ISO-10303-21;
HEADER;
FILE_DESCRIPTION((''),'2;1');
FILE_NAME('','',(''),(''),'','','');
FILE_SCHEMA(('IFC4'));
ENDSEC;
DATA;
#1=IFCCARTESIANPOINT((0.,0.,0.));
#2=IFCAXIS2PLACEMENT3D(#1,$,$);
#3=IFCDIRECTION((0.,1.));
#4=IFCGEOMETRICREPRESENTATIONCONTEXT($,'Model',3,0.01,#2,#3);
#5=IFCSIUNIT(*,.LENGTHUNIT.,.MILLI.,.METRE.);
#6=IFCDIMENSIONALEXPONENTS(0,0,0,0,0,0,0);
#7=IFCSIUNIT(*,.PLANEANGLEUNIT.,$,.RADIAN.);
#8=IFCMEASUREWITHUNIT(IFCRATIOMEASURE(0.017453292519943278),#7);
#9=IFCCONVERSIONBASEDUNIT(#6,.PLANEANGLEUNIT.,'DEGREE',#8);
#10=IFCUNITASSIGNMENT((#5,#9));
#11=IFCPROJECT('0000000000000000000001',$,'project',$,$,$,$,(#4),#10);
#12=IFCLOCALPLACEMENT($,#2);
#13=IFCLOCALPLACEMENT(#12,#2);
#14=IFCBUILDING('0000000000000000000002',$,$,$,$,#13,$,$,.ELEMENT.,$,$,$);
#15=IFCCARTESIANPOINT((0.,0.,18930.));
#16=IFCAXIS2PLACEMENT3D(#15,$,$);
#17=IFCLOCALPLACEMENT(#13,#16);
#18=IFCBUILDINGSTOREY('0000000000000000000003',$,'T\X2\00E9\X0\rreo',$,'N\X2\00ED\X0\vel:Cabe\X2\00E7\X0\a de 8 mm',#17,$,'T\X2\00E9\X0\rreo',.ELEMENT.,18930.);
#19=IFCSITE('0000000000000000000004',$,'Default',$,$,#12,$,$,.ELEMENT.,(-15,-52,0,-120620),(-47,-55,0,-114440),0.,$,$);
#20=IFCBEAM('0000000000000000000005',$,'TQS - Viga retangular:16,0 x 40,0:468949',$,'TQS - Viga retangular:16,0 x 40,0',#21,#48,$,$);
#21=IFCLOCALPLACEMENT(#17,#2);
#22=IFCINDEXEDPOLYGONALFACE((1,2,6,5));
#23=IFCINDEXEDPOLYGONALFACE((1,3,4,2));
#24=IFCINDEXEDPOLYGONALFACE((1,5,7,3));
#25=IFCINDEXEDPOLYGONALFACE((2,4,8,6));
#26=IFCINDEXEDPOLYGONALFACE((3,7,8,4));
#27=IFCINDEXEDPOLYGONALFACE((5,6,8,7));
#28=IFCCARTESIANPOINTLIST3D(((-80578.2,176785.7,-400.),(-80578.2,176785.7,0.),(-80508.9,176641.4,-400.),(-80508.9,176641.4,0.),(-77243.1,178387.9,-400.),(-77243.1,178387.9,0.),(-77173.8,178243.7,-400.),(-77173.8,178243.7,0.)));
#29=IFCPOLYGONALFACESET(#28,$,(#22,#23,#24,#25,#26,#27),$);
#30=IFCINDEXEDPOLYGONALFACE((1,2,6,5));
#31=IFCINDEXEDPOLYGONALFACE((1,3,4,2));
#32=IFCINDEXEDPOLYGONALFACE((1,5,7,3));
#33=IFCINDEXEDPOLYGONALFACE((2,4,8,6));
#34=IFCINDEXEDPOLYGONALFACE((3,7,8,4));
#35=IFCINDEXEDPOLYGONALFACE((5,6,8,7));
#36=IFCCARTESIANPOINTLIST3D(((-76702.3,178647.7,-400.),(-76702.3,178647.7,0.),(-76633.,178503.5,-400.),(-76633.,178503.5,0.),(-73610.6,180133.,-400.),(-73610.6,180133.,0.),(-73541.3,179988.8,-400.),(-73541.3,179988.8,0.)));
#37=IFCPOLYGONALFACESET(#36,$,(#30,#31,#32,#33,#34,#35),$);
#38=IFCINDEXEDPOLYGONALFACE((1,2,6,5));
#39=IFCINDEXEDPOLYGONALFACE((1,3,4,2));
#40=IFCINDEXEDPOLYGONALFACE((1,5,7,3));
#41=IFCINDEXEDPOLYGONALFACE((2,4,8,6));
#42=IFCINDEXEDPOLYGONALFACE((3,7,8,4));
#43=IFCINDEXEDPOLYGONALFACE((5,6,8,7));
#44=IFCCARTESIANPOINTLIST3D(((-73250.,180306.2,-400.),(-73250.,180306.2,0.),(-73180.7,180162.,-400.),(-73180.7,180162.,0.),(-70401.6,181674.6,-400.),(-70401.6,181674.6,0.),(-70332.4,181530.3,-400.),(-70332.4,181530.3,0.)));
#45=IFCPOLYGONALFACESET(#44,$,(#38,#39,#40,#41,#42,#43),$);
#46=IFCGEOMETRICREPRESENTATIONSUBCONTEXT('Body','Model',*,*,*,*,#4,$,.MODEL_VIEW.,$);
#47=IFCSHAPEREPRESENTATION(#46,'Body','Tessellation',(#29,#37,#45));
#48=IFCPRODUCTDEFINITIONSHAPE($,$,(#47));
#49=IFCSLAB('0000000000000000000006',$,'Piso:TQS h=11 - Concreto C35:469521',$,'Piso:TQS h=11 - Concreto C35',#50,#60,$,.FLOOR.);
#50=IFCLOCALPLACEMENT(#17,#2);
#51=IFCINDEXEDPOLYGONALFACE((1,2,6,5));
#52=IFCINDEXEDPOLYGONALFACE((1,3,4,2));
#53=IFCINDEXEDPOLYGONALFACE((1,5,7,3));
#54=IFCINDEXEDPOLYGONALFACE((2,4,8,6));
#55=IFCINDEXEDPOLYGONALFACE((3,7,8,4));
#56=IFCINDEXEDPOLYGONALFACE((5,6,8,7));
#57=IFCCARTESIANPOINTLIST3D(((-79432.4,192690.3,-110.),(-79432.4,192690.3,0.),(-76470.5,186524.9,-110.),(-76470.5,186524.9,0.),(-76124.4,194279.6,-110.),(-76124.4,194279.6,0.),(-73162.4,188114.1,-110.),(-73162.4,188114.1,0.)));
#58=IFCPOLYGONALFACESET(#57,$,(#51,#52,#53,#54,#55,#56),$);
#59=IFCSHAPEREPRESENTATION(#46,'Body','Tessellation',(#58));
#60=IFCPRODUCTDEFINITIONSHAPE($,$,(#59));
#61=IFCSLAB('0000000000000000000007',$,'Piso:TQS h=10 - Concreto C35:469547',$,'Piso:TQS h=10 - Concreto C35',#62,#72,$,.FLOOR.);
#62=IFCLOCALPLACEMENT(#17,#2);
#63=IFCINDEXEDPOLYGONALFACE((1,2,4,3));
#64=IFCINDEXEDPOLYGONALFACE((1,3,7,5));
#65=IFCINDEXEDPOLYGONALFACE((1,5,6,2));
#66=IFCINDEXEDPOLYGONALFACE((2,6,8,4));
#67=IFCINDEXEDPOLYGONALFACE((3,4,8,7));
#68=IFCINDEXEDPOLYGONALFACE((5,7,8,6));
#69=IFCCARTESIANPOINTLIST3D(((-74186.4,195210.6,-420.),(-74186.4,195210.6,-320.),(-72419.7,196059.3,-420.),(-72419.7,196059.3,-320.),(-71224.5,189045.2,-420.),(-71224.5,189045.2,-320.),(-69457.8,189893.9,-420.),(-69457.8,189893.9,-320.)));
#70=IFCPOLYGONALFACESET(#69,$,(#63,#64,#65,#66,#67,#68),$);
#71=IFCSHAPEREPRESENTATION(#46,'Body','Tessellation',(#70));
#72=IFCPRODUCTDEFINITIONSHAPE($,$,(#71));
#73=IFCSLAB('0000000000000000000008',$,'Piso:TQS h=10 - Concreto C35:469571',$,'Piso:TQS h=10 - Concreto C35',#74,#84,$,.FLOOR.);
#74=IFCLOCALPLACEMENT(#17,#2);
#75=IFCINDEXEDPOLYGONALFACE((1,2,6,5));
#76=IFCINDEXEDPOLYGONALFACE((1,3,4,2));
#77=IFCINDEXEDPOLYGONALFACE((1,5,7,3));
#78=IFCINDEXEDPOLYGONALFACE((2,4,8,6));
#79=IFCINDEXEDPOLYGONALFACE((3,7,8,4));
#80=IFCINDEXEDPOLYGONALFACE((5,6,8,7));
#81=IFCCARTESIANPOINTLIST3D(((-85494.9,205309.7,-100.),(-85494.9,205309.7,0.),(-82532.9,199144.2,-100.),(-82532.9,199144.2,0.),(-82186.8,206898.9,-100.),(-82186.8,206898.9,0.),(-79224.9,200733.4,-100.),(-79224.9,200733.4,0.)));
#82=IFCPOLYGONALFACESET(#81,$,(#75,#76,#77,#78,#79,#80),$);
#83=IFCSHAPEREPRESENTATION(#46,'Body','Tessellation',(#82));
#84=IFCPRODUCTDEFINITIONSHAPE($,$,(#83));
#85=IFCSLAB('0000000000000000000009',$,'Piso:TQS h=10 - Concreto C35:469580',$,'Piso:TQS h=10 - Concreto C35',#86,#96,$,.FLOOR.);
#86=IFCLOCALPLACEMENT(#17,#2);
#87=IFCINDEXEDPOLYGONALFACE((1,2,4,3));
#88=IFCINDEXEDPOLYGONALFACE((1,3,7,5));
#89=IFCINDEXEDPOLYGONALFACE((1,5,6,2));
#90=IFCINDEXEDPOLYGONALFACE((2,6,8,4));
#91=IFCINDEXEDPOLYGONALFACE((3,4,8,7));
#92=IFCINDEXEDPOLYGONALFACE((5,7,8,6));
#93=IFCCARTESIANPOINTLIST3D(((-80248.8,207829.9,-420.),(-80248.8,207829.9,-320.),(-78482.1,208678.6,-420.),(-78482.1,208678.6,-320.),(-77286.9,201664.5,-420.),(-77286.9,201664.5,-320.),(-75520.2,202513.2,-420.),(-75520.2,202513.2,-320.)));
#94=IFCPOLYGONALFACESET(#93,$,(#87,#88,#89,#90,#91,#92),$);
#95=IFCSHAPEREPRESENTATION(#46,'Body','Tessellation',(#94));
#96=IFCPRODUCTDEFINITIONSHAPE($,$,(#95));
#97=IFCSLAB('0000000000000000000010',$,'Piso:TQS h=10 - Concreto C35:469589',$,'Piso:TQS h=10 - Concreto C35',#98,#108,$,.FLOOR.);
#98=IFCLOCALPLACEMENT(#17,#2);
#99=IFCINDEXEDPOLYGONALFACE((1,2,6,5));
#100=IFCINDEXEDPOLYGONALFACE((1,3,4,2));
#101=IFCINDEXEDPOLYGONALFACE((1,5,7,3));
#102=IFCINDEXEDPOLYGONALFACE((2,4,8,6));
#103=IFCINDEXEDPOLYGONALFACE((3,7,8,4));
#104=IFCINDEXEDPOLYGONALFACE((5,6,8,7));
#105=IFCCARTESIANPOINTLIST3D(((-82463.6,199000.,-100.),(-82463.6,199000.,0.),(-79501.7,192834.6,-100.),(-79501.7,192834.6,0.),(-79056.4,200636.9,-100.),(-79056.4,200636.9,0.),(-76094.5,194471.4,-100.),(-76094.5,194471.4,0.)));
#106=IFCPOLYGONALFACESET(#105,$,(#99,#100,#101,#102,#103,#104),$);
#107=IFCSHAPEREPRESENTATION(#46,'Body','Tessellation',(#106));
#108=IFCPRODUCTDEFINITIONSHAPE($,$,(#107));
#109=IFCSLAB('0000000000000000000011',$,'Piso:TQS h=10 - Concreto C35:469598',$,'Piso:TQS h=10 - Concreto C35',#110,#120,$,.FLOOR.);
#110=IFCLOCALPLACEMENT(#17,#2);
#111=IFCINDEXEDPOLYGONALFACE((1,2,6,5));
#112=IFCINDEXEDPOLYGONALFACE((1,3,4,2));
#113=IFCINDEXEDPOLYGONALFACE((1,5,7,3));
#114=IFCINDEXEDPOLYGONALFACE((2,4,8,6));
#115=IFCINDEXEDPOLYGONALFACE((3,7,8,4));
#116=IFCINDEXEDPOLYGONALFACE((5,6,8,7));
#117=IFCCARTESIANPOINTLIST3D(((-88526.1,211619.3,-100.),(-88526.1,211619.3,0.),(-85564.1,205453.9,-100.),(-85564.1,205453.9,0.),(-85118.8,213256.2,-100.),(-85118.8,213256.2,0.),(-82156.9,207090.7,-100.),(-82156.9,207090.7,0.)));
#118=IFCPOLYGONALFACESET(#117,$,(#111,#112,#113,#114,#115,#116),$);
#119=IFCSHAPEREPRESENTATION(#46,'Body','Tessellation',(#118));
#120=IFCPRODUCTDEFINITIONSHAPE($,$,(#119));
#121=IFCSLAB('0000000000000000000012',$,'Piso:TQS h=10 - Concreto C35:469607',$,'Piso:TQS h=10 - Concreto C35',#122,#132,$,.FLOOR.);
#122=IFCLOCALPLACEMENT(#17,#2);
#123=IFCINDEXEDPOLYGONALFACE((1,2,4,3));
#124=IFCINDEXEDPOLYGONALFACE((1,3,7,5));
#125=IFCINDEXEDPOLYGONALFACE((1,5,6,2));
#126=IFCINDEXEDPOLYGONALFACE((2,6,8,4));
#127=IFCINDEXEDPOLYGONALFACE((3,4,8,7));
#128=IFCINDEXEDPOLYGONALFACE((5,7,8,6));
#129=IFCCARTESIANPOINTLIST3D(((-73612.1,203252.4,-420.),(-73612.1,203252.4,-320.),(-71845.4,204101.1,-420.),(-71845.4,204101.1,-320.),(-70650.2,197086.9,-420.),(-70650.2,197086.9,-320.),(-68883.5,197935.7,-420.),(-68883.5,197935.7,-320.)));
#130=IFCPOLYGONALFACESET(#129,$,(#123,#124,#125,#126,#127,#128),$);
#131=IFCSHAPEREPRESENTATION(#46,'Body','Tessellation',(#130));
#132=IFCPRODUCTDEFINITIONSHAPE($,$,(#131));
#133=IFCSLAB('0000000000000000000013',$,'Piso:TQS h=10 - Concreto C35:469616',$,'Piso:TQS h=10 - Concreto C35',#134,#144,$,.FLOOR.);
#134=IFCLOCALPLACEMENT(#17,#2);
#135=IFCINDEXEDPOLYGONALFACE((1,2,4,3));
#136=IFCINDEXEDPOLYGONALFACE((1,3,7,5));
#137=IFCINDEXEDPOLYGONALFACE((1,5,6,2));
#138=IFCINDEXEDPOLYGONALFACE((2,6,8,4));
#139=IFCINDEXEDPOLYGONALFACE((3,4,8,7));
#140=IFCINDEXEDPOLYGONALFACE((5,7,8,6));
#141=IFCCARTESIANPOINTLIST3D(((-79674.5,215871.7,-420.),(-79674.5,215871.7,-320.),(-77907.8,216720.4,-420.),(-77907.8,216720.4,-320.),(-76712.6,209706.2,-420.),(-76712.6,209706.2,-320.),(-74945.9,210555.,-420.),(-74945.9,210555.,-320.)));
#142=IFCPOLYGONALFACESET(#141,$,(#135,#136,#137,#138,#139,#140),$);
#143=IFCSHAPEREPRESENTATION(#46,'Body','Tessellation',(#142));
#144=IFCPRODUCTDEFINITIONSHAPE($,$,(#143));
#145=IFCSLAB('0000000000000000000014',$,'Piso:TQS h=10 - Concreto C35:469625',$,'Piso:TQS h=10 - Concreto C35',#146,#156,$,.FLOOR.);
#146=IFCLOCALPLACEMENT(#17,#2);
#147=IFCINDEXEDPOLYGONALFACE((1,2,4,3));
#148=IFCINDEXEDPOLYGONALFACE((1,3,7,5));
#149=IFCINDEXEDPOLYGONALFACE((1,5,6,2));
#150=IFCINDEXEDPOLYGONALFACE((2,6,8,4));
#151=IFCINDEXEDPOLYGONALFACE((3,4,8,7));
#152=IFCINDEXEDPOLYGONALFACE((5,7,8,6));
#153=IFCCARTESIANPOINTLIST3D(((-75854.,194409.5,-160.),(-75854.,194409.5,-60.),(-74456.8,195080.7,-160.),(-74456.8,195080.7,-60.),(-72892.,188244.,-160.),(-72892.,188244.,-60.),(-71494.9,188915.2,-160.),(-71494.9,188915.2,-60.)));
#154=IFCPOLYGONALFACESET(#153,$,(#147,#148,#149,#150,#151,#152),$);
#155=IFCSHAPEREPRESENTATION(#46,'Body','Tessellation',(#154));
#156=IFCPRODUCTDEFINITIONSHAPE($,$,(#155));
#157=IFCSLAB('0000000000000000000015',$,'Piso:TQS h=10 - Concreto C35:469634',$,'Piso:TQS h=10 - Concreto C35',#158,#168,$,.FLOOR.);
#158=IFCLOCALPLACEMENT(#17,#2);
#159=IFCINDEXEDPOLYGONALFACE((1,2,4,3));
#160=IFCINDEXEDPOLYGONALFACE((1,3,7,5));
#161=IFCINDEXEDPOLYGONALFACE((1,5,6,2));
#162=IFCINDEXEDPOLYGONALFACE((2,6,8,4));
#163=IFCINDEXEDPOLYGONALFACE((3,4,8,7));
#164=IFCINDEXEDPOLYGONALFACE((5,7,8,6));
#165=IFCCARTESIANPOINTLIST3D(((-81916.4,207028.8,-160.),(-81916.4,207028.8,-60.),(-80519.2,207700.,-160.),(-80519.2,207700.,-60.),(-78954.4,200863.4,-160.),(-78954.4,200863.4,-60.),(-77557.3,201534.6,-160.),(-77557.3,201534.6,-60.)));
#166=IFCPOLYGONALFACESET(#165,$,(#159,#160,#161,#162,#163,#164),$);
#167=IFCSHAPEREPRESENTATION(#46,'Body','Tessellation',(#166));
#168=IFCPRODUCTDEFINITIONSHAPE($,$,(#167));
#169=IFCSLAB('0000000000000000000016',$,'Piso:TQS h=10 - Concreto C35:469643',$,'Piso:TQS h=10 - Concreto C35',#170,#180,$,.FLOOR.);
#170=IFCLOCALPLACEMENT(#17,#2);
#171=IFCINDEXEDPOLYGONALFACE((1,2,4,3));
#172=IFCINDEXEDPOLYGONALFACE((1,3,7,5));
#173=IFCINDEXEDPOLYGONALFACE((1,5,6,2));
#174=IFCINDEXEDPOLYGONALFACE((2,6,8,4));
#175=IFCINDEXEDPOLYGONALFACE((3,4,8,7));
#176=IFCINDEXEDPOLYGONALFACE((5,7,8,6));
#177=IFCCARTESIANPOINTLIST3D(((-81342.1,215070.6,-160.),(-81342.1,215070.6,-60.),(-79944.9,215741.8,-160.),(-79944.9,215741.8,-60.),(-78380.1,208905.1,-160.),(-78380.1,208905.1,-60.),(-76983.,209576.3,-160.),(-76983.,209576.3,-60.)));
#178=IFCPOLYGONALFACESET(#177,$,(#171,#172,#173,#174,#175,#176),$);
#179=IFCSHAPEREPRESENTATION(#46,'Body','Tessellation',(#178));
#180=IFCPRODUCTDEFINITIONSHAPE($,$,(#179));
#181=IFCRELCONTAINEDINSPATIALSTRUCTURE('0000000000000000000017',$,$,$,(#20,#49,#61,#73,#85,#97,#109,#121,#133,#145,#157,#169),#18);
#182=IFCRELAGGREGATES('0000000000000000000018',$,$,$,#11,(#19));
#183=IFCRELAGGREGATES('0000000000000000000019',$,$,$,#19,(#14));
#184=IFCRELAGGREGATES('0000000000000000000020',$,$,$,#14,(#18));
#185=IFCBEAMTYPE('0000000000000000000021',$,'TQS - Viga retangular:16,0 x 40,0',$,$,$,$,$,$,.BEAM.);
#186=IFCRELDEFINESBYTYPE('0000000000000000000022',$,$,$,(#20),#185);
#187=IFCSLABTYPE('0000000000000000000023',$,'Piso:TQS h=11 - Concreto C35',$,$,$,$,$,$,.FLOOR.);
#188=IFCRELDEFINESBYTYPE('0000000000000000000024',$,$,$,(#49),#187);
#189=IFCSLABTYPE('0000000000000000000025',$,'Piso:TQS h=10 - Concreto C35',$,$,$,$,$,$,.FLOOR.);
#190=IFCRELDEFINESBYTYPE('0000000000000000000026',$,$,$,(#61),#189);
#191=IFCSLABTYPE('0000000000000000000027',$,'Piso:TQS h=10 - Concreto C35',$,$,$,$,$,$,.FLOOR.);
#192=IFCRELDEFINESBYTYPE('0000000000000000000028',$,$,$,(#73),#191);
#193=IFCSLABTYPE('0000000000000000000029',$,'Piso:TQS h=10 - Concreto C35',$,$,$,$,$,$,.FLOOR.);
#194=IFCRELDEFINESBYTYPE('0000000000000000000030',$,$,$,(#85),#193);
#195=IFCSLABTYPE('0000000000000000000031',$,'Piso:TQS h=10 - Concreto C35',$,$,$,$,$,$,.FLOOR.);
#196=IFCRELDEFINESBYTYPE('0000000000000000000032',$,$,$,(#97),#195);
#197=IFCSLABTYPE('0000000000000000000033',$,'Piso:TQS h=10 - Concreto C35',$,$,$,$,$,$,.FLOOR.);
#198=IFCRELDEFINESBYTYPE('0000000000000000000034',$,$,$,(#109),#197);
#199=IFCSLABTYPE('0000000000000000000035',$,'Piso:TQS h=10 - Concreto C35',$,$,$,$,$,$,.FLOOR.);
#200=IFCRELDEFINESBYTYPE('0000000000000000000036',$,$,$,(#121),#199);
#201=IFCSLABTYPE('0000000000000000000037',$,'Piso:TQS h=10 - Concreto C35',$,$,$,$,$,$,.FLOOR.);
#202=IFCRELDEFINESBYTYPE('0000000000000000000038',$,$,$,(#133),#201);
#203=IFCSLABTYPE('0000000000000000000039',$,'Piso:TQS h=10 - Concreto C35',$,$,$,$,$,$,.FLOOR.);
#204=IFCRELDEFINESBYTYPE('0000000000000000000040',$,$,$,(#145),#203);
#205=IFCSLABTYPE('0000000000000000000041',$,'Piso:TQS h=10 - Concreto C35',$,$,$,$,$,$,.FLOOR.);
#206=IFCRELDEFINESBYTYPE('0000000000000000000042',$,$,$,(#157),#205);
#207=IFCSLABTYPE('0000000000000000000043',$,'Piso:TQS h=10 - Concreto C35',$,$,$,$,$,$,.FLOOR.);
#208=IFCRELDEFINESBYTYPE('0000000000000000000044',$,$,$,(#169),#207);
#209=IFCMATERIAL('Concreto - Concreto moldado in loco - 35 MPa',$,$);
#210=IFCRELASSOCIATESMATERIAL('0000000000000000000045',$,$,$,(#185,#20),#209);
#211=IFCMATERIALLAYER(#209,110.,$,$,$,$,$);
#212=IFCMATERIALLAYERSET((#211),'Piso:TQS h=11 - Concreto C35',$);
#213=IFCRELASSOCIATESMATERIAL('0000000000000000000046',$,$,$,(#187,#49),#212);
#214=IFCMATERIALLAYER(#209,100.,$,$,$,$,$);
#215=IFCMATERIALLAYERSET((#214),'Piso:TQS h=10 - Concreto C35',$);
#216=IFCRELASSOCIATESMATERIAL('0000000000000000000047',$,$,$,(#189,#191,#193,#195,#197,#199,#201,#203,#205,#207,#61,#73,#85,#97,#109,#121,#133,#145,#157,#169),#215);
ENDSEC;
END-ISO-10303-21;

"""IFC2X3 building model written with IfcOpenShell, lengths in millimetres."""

from ifc_helpers import new_model, entity, si_unit, converted_unit, direction, frame, frame_2d, origin, place, context, subcontext, project, spatial, rectangle, extrude, source, transform, mapped, material, layer, layer_set, layer_usage, type_object, type_shapes, element, save


model = new_model("IFC2X3")

# Units and contexts
model_context = context("Model", 3, precision=0.01, world=origin(), true_north=direction((0.0, 1.0)))
body_context = subcontext(model_context, "Body", "Model", "MODEL_VIEW")
ifc_project = project(units=[si_unit("LENGTHUNIT", "METRE", prefix="MILLI"), converted_unit("PLANEANGLEUNIT", "DEGREE", entity("IfcRatioMeasure", 0.017453292519943278), si_unit("PLANEANGLEUNIT", "RADIAN"), dimensions=[0, 0, 0, 0, 0, 0, 0])], contexts=[model_context])

# Site, building, storey
site_placement = place(None, origin())
site = spatial("IfcSite", under=ifc_project, at=site_placement, Name="Default", CompositionType="ELEMENT", RefLatitude=(-15, -52, 0, -120620), RefLongitude=(-47, -55, 0, -114440), RefElevation=0.0)
building_placement = place(site_placement, origin())
building = spatial("IfcBuilding", under=site, at=building_placement, CompositionType="ELEMENT")
storey_placement = place(building_placement, frame((0.0, 0.0, 18930.0)))
storey = spatial("IfcBuildingStorey", under=building, at=storey_placement, Name="Térreo", ObjectType="Nível:Cabeça de 8 mm", LongName="Térreo", CompositionType="ELEMENT", Elevation=18930.0)

# Beam
ifc_material_1 = material(Name="Concreto - Concreto moldado in loco - 35 MPa")
beam_type_1 = type_object("IfcBeamType", Name="TQS - Viga retangular:16,0 x 40,0", PredefinedType="BEAM", material=ifc_material_1)
shared_shape_1 = source(origin(), body_context, "Body", "SweptSolid", [
    extrude(rectangle(XDim=400.0, YDim=160.0, at=frame_2d((0.0, 0.0), x_axis=(1.0, 0.0))), frame((-77208.5, 178315.8, 18730.0), z_axis=(-0.90138, -0.43303, 0.0), x_axis=(0.0, 0.0, -1.0)), (0.0, 0.0, 1.0), 3700.0),
    extrude(rectangle(XDim=400.0, YDim=160.0, at=frame_2d((0.0, 0.0), x_axis=(1.0, 0.0))), frame((-73575.9, 180060.9, 18730.0), z_axis=(-0.90138, -0.43303, 0.0), x_axis=(0.0, 0.0, -1.0)), (0.0, 0.0, 1.0), 3430.0),
    extrude(rectangle(XDim=400.0, YDim=160.0, at=frame_2d((0.0, 0.0), x_axis=(1.0, 0.0))), frame((-70367.0, 181602.5, 18730.0), z_axis=(-0.90138, -0.43303, 0.0), x_axis=(0.0, 0.0, -1.0)), (0.0, 0.0, 1.0), 3160.0),
])
type_shapes(beam_type_1, [shared_shape_1])
beam_1_placement = place(storey_placement, frame((0.0, 0.0, -18930.0)))
element("IfcBeam", 1, at=beam_1_placement, inside=storey, type_object=beam_type_1, material=ifc_material_1, Name="TQS - Viga retangular:16,0 x 40,0:468949", ObjectType="TQS - Viga retangular:16,0 x 40,0", context=body_context, shape_type="MappedRepresentation", body=[
    mapped(shared_shape_1, transform((0.0, 0.0, 0.0), scale=1.0)),
])

# Slabs
ifc_layer_1 = layer(ifc_material_1, 110.0)
ifc_layer_set_1 = layer_set([ifc_layer_1], Name="Piso:TQS h=11 - Concreto C35")
ifc_layer_usage_1 = layer_usage(ifc_layer_set_1, "AXIS3", "POSITIVE", 0.0)
slab_type_1 = type_object("IfcSlabType", Name="Piso:TQS h=11 - Concreto C35", PredefinedType="FLOOR", material=ifc_layer_set_1)
slab_1_placement = place(storey_placement, origin())
element("IfcSlab", 2, at=slab_1_placement, inside=storey, type_object=slab_type_1, material=ifc_layer_usage_1, Name="Piso:TQS h=11 - Concreto C35:469521", ObjectType="Piso:TQS h=11 - Concreto C35", PredefinedType="FLOOR", context=body_context, shape_type="SweptSolid", body=[
    extrude(rectangle(XDim=6840.0, YDim=3670.0, at=frame_2d((0.0, 0.0), x_axis=(1.0, 0.0))), frame((-76297.4, 190402.2, 0.0), z_axis=(0.0, 0.0, -1.0), x_axis=(0.43303, -0.90138, 0.0)), (0.0, 0.0, 1.0), 110.0),
])
ifc_layer_2 = layer(ifc_material_1, 100.0)
ifc_layer_set_2 = layer_set([ifc_layer_2], Name="Piso:TQS h=10 - Concreto C35")
ifc_layer_usage_2 = layer_usage(ifc_layer_set_2, "AXIS3", "POSITIVE", 0.0)
slab_type_2 = type_object("IfcSlabType", Name="Piso:TQS h=10 - Concreto C35", PredefinedType="FLOOR", material=ifc_layer_set_2)
slab_2_placement = place(storey_placement, origin())
element("IfcSlab", 3, at=slab_2_placement, inside=storey, type_object=slab_type_2, material=ifc_layer_usage_2, Name="Piso:TQS h=10 - Concreto C35:469547", ObjectType="Piso:TQS h=10 - Concreto C35", PredefinedType="FLOOR", context=body_context, shape_type="SweptSolid", body=[
    extrude(rectangle(XDim=6840.0, YDim=1960.0, at=frame_2d((0.0, 0.0), x_axis=(1.0, 0.0))), frame((-71822.1, 192552.2, -320.0), z_axis=(0.0, 0.0, -1.0), x_axis=(0.43303, -0.90138, 0.0)), (0.0, 0.0, 1.0), 100.0),
])
ifc_layer_usage_3 = layer_usage(ifc_layer_set_2, "AXIS3", "POSITIVE", 0.0)
slab_type_3 = type_object("IfcSlabType", Name="Piso:TQS h=10 - Concreto C35", PredefinedType="FLOOR", material=ifc_layer_set_2)
slab_3_placement = place(storey_placement, origin())
element("IfcSlab", 4, at=slab_3_placement, inside=storey, type_object=slab_type_3, material=ifc_layer_usage_3, Name="Piso:TQS h=10 - Concreto C35:469571", ObjectType="Piso:TQS h=10 - Concreto C35", PredefinedType="FLOOR", context=body_context, shape_type="SweptSolid", body=[
    extrude(rectangle(XDim=6840.0, YDim=3670.0, at=frame_2d((0.0, 0.0), x_axis=(1.0, 0.0))), frame((-82359.9, 203021.6, 0.0), z_axis=(0.0, 0.0, -1.0), x_axis=(0.43303, -0.90138, 0.0)), (0.0, 0.0, 1.0), 100.0),
])
ifc_layer_usage_4 = layer_usage(ifc_layer_set_2, "AXIS3", "POSITIVE", 0.0)
slab_type_4 = type_object("IfcSlabType", Name="Piso:TQS h=10 - Concreto C35", PredefinedType="FLOOR", material=ifc_layer_set_2)
slab_4_placement = place(storey_placement, origin())
element("IfcSlab", 5, at=slab_4_placement, inside=storey, type_object=slab_type_4, material=ifc_layer_usage_4, Name="Piso:TQS h=10 - Concreto C35:469580", ObjectType="Piso:TQS h=10 - Concreto C35", PredefinedType="FLOOR", context=body_context, shape_type="SweptSolid", body=[
    extrude(rectangle(XDim=6840.0, YDim=1960.0, at=frame_2d((0.0, 0.0), x_axis=(1.0, 0.0))), frame((-77884.5, 205171.6, -320.0), z_axis=(0.0, 0.0, -1.0), x_axis=(0.43303, -0.90138, 0.0)), (0.0, 0.0, 1.0), 100.0),
])
ifc_layer_usage_5 = layer_usage(ifc_layer_set_2, "AXIS3", "POSITIVE", 0.0)
slab_type_5 = type_object("IfcSlabType", Name="Piso:TQS h=10 - Concreto C35", PredefinedType="FLOOR", material=ifc_layer_set_2)
slab_5_placement = place(storey_placement, origin())
element("IfcSlab", 6, at=slab_5_placement, inside=storey, type_object=slab_type_5, material=ifc_layer_usage_5, Name="Piso:TQS h=10 - Concreto C35:469589", ObjectType="Piso:TQS h=10 - Concreto C35", PredefinedType="FLOOR", context=body_context, shape_type="SweptSolid", body=[
    extrude(rectangle(XDim=6840.0, YDim=3780.0, at=frame_2d((0.0, 0.0), x_axis=(1.0, 0.0))), frame((-79279.1, 196735.7, 0.0), z_axis=(0.0, 0.0, -1.0), x_axis=(0.43303, -0.90138, 0.0)), (0.0, 0.0, 1.0), 100.0),
])
ifc_layer_usage_6 = layer_usage(ifc_layer_set_2, "AXIS3", "POSITIVE", 0.0)
slab_type_6 = type_object("IfcSlabType", Name="Piso:TQS h=10 - Concreto C35", PredefinedType="FLOOR", material=ifc_layer_set_2)
slab_6_placement = place(storey_placement, origin())
element("IfcSlab", 7, at=slab_6_placement, inside=storey, type_object=slab_type_6, material=ifc_layer_usage_6, Name="Piso:TQS h=10 - Concreto C35:469598", ObjectType="Piso:TQS h=10 - Concreto C35", PredefinedType="FLOOR", context=body_context, shape_type="SweptSolid", body=[
    extrude(rectangle(XDim=6840.0, YDim=3780.0, at=frame_2d((0.0, 0.0), x_axis=(1.0, 0.0))), frame((-85341.5, 209355.0, 0.0), z_axis=(0.0, 0.0, -1.0), x_axis=(0.43303, -0.90138, 0.0)), (0.0, 0.0, 1.0), 100.0),
])
ifc_layer_usage_7 = layer_usage(ifc_layer_set_2, "AXIS3", "POSITIVE", 0.0)
slab_type_7 = type_object("IfcSlabType", Name="Piso:TQS h=10 - Concreto C35", PredefinedType="FLOOR", material=ifc_layer_set_2)
slab_7_placement = place(storey_placement, origin())
element("IfcSlab", 8, at=slab_7_placement, inside=storey, type_object=slab_type_7, material=ifc_layer_usage_7, Name="Piso:TQS h=10 - Concreto C35:469607", ObjectType="Piso:TQS h=10 - Concreto C35", PredefinedType="FLOOR", context=body_context, shape_type="SweptSolid", body=[
    extrude(rectangle(XDim=6840.0, YDim=1960.0, at=frame_2d((0.0, 0.0), x_axis=(1.0, 0.0))), frame((-71247.8, 200594.0, -320.0), z_axis=(0.0, 0.0, -1.0), x_axis=(0.43303, -0.90138, 0.0)), (0.0, 0.0, 1.0), 100.0),
])
ifc_layer_usage_8 = layer_usage(ifc_layer_set_2, "AXIS3", "POSITIVE", 0.0)
slab_type_8 = type_object("IfcSlabType", Name="Piso:TQS h=10 - Concreto C35", PredefinedType="FLOOR", material=ifc_layer_set_2)
slab_8_placement = place(storey_placement, origin())
element("IfcSlab", 9, at=slab_8_placement, inside=storey, type_object=slab_type_8, material=ifc_layer_usage_8, Name="Piso:TQS h=10 - Concreto C35:469616", ObjectType="Piso:TQS h=10 - Concreto C35", PredefinedType="FLOOR", context=body_context, shape_type="SweptSolid", body=[
    extrude(rectangle(XDim=6840.0, YDim=1960.0, at=frame_2d((0.0, 0.0), x_axis=(1.0, 0.0))), frame((-77310.2, 213213.3, -320.0), z_axis=(0.0, 0.0, -1.0), x_axis=(0.43303, -0.90138, 0.0)), (0.0, 0.0, 1.0), 100.0),
])
ifc_layer_usage_9 = layer_usage(ifc_layer_set_2, "AXIS3", "POSITIVE", 0.0)
slab_type_9 = type_object("IfcSlabType", Name="Piso:TQS h=10 - Concreto C35", PredefinedType="FLOOR", material=ifc_layer_set_2)
slab_9_placement = place(storey_placement, origin())
element("IfcSlab", 10, at=slab_9_placement, inside=storey, type_object=slab_type_9, material=ifc_layer_usage_9, Name="Piso:TQS h=10 - Concreto C35:469625", ObjectType="Piso:TQS h=10 - Concreto C35", PredefinedType="FLOOR", context=body_context, shape_type="SweptSolid", body=[
    extrude(rectangle(XDim=6840.0, YDim=1550.0, at=frame_2d((0.0, 0.0), x_axis=(1.0, 0.0))), frame((-73674.4, 191662.4, -60.0), z_axis=(0.0, 0.0, -1.0), x_axis=(0.43303, -0.90138, 0.0)), (0.0, 0.0, 1.0), 100.0),
])
ifc_layer_usage_10 = layer_usage(ifc_layer_set_2, "AXIS3", "POSITIVE", 0.0)
slab_type_10 = type_object("IfcSlabType", Name="Piso:TQS h=10 - Concreto C35", PredefinedType="FLOOR", material=ifc_layer_set_2)
slab_10_placement = place(storey_placement, origin())
element("IfcSlab", 11, at=slab_10_placement, inside=storey, type_object=slab_type_10, material=ifc_layer_usage_10, Name="Piso:TQS h=10 - Concreto C35:469634", ObjectType="Piso:TQS h=10 - Concreto C35", PredefinedType="FLOOR", context=body_context, shape_type="SweptSolid", body=[
    extrude(rectangle(XDim=6840.0, YDim=1550.0, at=frame_2d((0.0, 0.0), x_axis=(1.0, 0.0))), frame((-79736.8, 204281.7, -60.0), z_axis=(0.0, 0.0, -1.0), x_axis=(0.43303, -0.90138, 0.0)), (0.0, 0.0, 1.0), 100.0),
])
ifc_layer_usage_11 = layer_usage(ifc_layer_set_2, "AXIS3", "POSITIVE", 0.0)
slab_type_11 = type_object("IfcSlabType", Name="Piso:TQS h=10 - Concreto C35", PredefinedType="FLOOR", material=ifc_layer_set_2)
slab_11_placement = place(storey_placement, origin())
element("IfcSlab", 12, at=slab_11_placement, inside=storey, type_object=slab_type_11, material=ifc_layer_usage_11, Name="Piso:TQS h=10 - Concreto C35:469643", ObjectType="Piso:TQS h=10 - Concreto C35", PredefinedType="FLOOR", context=body_context, shape_type="SweptSolid", body=[
    extrude(rectangle(XDim=6840.0, YDim=1550.0, at=frame_2d((0.0, 0.0), x_axis=(1.0, 0.0))), frame((-79162.5, 212323.5, -60.0), z_axis=(0.0, 0.0, -1.0), x_axis=(0.43303, -0.90138, 0.0)), (0.0, 0.0, 1.0), 100.0),
])

save(model, "model.ifc")
